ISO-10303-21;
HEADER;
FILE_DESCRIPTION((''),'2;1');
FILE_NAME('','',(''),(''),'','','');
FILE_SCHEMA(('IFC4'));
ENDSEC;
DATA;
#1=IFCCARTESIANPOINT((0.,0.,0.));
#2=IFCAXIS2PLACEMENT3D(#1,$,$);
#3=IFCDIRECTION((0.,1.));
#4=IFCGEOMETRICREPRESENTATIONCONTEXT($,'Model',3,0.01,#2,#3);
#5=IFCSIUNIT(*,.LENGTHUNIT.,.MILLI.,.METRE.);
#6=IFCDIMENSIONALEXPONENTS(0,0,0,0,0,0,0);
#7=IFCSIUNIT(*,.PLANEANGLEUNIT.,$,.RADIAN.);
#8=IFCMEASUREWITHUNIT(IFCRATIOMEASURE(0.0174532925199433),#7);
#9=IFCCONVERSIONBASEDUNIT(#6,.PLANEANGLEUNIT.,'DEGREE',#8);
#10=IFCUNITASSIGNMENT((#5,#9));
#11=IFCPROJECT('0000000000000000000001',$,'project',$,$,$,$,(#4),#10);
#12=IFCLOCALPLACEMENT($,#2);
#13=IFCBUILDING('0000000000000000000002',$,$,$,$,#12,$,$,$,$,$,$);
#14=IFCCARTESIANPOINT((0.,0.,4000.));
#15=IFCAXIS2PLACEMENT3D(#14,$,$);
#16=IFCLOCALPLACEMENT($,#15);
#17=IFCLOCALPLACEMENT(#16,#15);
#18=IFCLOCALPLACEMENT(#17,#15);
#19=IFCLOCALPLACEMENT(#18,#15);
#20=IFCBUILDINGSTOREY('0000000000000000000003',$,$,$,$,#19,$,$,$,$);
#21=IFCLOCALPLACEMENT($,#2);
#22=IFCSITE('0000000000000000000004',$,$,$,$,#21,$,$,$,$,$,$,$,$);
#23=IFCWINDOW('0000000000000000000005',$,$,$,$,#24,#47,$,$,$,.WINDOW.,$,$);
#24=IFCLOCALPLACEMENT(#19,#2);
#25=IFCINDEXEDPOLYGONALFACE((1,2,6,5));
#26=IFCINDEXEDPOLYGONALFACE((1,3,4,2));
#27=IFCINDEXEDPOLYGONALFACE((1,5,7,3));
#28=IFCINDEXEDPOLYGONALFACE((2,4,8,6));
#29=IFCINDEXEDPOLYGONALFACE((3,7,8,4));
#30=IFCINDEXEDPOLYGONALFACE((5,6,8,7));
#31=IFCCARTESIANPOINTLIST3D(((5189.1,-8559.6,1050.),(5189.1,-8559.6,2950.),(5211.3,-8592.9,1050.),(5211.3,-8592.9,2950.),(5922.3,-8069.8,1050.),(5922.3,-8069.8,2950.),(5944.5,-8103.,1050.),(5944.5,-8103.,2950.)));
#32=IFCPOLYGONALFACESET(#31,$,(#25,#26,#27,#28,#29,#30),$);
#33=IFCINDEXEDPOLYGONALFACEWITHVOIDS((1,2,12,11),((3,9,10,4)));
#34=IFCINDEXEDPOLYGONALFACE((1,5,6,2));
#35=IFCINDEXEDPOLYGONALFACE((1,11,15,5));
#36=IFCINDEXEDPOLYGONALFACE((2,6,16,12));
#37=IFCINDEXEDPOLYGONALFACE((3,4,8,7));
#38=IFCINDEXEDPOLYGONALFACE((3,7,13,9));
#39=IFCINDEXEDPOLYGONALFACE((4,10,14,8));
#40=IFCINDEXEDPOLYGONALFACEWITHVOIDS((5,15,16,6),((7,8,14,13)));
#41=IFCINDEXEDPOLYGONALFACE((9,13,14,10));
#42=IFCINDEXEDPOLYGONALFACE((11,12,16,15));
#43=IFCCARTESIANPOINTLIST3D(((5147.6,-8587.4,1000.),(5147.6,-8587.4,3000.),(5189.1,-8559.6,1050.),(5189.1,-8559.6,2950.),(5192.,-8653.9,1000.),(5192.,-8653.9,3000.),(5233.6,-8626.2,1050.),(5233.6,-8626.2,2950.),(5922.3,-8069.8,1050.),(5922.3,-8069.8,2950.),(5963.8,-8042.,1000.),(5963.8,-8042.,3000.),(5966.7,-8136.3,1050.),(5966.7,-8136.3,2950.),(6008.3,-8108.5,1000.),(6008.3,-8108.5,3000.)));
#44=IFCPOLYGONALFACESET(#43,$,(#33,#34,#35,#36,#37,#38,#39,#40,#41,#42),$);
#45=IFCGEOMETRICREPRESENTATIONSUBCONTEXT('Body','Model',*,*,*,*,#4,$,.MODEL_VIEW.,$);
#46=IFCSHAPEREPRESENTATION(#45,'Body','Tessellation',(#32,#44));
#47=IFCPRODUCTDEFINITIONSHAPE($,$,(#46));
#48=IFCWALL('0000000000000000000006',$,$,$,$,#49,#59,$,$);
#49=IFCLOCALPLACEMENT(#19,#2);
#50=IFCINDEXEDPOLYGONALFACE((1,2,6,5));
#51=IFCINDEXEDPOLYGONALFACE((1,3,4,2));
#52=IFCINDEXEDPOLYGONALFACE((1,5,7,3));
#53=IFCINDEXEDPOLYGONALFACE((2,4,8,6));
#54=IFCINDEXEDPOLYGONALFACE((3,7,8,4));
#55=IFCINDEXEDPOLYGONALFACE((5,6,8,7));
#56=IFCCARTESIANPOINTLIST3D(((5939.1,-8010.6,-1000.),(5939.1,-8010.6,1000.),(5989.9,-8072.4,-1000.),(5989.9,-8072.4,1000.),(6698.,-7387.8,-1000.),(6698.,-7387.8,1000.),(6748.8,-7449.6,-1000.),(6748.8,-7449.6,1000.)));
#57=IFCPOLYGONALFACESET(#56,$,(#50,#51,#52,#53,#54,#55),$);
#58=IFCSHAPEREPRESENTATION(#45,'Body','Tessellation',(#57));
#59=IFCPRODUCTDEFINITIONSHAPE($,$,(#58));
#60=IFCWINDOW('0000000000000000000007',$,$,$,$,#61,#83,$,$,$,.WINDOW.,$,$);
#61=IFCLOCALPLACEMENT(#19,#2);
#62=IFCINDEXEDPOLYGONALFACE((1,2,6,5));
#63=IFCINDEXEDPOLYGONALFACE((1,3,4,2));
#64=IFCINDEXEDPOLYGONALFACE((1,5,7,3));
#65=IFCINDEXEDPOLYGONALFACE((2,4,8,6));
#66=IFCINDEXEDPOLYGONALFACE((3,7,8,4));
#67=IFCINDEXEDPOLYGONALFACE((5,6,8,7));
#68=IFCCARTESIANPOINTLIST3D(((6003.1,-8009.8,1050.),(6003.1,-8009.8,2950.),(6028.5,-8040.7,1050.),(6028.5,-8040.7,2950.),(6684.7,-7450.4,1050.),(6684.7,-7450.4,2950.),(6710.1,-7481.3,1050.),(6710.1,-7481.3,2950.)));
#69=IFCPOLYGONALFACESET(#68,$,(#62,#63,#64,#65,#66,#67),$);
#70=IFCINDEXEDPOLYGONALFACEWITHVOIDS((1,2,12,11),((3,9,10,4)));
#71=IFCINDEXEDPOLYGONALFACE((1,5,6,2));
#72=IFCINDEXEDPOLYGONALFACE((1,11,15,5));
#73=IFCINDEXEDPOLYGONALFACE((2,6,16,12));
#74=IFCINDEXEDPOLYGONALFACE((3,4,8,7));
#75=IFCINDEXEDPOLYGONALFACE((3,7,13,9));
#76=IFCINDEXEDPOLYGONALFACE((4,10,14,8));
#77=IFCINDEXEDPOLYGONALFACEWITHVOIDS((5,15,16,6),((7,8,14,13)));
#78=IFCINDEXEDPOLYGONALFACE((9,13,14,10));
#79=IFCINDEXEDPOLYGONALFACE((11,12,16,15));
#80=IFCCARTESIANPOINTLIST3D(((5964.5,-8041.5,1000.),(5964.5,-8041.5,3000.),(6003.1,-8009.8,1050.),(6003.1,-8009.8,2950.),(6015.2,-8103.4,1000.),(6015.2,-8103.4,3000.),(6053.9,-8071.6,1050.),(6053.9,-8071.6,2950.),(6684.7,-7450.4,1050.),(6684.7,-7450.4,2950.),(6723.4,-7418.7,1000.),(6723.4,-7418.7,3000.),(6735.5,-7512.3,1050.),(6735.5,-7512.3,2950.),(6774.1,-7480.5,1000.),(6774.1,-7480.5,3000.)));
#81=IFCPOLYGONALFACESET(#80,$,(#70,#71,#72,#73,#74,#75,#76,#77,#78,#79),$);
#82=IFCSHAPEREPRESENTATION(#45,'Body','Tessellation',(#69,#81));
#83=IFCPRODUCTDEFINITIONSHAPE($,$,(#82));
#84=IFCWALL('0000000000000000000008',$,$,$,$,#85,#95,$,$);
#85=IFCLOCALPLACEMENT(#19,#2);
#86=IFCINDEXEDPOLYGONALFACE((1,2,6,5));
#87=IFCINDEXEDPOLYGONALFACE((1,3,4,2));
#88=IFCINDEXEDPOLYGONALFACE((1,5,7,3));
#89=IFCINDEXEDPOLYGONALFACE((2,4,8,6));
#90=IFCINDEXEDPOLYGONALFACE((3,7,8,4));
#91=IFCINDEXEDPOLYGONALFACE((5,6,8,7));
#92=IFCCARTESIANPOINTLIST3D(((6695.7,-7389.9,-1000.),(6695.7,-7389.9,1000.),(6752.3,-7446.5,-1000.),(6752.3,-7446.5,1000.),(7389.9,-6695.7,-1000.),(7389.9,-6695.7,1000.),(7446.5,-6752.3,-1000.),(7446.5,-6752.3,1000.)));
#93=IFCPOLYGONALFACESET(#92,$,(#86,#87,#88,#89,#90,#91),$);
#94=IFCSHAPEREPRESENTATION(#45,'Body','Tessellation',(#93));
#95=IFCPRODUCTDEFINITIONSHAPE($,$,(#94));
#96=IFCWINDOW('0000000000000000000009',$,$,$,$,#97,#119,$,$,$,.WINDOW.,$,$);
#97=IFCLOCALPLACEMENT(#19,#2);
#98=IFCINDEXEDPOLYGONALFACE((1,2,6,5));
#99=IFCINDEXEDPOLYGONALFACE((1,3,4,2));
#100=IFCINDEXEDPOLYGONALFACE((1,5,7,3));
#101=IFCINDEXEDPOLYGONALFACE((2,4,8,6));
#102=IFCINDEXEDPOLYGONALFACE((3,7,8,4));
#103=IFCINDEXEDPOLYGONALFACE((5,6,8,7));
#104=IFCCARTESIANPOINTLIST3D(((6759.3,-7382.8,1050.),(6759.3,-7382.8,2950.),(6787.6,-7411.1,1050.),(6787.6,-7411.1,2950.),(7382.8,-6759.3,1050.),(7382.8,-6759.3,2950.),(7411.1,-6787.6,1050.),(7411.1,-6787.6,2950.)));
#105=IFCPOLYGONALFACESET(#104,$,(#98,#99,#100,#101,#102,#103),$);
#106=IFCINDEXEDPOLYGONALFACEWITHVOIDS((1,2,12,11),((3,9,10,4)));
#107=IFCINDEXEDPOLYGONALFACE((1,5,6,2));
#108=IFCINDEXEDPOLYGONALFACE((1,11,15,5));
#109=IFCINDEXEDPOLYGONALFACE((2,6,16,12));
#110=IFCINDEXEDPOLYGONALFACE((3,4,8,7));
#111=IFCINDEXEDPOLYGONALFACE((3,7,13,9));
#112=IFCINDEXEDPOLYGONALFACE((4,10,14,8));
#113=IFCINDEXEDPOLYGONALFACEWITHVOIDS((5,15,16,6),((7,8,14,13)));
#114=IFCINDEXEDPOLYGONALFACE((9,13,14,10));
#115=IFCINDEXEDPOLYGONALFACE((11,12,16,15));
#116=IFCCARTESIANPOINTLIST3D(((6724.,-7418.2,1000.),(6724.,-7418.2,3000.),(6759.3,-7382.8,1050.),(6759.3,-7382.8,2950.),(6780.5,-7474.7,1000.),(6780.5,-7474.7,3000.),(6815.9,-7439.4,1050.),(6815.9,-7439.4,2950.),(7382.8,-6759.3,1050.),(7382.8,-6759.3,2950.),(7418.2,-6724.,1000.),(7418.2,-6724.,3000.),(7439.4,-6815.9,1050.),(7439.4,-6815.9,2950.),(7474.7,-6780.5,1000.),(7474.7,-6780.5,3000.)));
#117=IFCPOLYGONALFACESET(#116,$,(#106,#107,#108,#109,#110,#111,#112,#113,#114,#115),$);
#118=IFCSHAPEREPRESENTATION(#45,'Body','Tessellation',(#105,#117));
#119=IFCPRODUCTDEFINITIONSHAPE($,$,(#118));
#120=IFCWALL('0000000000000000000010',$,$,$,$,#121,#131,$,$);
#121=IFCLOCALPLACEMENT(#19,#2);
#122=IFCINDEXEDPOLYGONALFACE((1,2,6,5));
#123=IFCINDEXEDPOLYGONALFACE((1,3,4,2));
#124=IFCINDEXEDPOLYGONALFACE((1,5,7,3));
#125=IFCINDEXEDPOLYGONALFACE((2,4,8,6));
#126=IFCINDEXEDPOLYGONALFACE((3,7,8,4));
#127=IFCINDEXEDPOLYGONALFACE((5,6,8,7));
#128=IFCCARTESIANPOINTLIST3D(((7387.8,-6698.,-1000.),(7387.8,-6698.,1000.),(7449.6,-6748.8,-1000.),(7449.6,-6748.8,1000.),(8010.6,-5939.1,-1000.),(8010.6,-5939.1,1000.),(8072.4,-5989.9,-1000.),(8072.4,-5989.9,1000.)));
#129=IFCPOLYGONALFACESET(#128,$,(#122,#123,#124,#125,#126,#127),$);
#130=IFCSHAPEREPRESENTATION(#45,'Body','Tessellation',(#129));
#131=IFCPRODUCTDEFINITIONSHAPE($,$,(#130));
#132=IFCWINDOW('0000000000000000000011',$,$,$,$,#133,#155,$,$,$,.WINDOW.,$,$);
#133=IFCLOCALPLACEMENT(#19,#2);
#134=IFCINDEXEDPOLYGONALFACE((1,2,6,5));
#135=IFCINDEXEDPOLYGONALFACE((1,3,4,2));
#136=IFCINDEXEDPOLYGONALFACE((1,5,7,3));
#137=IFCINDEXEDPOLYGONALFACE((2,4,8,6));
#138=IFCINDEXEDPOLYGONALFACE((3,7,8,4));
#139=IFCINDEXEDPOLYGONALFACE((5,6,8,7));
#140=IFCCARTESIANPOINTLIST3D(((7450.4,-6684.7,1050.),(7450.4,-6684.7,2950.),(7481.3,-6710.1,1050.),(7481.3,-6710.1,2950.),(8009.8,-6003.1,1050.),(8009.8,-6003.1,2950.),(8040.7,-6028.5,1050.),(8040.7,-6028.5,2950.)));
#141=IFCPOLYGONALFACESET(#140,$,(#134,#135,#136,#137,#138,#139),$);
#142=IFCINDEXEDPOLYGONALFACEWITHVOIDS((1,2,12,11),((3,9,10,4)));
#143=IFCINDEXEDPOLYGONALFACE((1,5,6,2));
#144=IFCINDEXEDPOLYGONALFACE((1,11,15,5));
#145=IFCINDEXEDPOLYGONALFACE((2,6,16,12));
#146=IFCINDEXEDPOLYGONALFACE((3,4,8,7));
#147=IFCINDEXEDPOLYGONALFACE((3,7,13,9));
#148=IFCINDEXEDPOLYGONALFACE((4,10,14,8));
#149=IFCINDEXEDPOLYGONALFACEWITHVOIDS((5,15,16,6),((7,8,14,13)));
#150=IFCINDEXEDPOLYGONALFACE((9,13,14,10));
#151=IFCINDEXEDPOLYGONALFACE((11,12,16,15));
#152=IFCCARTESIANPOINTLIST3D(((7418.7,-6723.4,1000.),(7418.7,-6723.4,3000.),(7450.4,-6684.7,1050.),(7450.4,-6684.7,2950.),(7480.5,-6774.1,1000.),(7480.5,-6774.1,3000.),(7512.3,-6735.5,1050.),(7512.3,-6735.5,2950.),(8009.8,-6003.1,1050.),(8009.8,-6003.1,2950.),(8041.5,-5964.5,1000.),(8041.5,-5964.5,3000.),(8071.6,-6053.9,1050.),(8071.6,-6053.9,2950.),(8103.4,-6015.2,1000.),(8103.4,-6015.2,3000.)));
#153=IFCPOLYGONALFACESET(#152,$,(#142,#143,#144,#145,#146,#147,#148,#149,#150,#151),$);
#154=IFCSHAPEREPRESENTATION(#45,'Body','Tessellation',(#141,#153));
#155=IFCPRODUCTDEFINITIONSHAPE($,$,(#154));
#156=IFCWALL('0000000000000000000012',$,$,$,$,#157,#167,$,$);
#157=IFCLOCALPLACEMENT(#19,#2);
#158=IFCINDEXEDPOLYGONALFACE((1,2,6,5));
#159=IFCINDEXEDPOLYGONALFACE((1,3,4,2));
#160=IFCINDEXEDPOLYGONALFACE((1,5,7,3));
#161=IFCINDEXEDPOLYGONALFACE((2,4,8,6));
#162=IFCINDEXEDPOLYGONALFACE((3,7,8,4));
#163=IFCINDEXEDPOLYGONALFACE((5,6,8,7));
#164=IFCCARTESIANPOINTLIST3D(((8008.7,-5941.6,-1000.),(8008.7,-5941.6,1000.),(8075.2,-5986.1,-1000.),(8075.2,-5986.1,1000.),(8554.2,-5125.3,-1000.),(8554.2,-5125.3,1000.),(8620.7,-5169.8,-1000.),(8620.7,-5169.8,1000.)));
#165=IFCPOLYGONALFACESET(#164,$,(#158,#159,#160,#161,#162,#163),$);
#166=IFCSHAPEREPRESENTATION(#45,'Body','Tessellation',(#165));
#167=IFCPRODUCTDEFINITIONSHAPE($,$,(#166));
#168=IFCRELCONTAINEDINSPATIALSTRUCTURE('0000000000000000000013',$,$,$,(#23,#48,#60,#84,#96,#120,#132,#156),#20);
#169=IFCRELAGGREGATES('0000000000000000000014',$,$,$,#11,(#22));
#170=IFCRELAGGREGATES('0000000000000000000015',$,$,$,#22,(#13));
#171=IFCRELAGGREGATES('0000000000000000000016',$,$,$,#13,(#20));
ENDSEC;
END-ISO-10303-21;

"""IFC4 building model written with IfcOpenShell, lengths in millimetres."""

from ifc_helpers import new_model, entity, si_unit, converted_unit, direction, frame, origin, origin_2d, place, context, subcontext, project, spatial, rectangle, extrude, element, save


model = new_model("IFC4")

# Units and contexts
model_context = context("Model", 3, precision=0.01, world=origin(), true_north=direction((0.0, 1.0)))
body_context = subcontext(model_context, "Body", "Model", "MODEL_VIEW")
ifc_project = project(units=[si_unit("LENGTHUNIT", "METRE", prefix="MILLI"), converted_unit("PLANEANGLEUNIT", "DEGREE", entity("IfcRatioMeasure", 0.0174532925199433), si_unit("PLANEANGLEUNIT", "RADIAN"), dimensions=[0, 0, 0, 0, 0, 0, 0])], contexts=[model_context])

# Site, building, storey
site_placement = place(None, origin())
site = spatial("IfcSite", under=ifc_project, at=site_placement)
building_placement = place(None, origin())
building = spatial("IfcBuilding", under=site, at=building_placement)
placement_1 = place(None, frame((0.0, 0.0, 4000.0)))
placement_2 = place(placement_1, frame((0.0, 0.0, 4000.0)))
placement_3 = place(placement_2, frame((0.0, 0.0, 4000.0)))
storey_placement = place(placement_3, frame((0.0, 0.0, 4000.0)))
storey = spatial("IfcBuildingStorey", under=building, at=storey_placement)

# Shared definitions
cartesian_point_1 = entity("IfcCartesianPoint", [-440.9, -950.0])
shared_polyline = entity("IfcPolyline", [cartesian_point_1, entity("IfcCartesianPoint", [-440.9, 950.0]), entity("IfcCartesianPoint", [-440.9, 950.0]), entity("IfcCartesianPoint", [440.9, 950.0]), entity("IfcCartesianPoint", [440.9, 950.0]), entity("IfcCartesianPoint", [440.9, -950.0]), entity("IfcCartesianPoint", [440.9, -950.0]), entity("IfcCartesianPoint", [-440.9, -950.0]), cartesian_point_1])

# Window
window_1_placement = place(storey_placement, frame((5555.7, -8314.7, 2000.0), z_axis=(0.0, 0.0, 1.0), x_axis=(8314.697373, 5555.700459, 0.0)))
cartesian_point_2 = entity("IfcCartesianPoint", [-490.9, -1000.0])
element("IfcWindow", 1, at=window_1_placement, inside=storey, PredefinedType="WINDOW", context=body_context, shape_type="SweptSolid", body=[
    entity("IfcExtrudedAreaSolid", entity("IfcArbitraryClosedProfileDef", "AREA", None, shared_polyline), entity("IfcAxis2Placement3D", entity("IfcCartesianPoint", [0.0, 0.0, 0.0]), entity("IfcDirection", [0.0, -1.0, 0.0]), entity("IfcDirection", [1.0, 0.0, 0.0])), entity("IfcDirection", [0.0, 0.0, 1.0]), 40.0),
    entity("IfcExtrudedAreaSolid", entity("IfcArbitraryProfileDefWithVoids", "AREA", None, entity("IfcPolyline", [cartesian_point_2, entity("IfcCartesianPoint", [-490.9, 1000.0]), entity("IfcCartesianPoint", [-490.9, 1000.0]), entity("IfcCartesianPoint", [490.9, 1000.0]), entity("IfcCartesianPoint", [490.9, 1000.0]), entity("IfcCartesianPoint", [490.9, -1000.0]), entity("IfcCartesianPoint", [490.9, -1000.0]), entity("IfcCartesianPoint", [-490.9, -1000.0]), cartesian_point_2]), [shared_polyline]), entity("IfcAxis2Placement3D", entity("IfcCartesianPoint", [0.0, 0.0, 0.0]), entity("IfcDirection", [0.0, -1.0, 0.0]), entity("IfcDirection", [1.0, 0.0, 0.0])), entity("IfcDirection", [0.0, 0.0, 1.0]), 80.0),
])

# Wall
wall_1_placement = place(storey_placement, frame((6343.9, -7730.1, -1000.0), z_axis=(0.0, 0.0, 1.0), x_axis=(7730.104195, 6343.933254, 0.0)))
element("IfcWall", 2, at=wall_1_placement, inside=storey, context=body_context, shape_type="SweptSolid", body=[
    extrude(rectangle(XDim=981.7, YDim=80.0, at=origin_2d()), origin(), (0.0, 0.0, 1.0), 2000.0),
])

# Window
window_2_placement = place(storey_placement, frame((6343.9, -7730.1, 2000.0), z_axis=(0.0, 0.0, 1.0), x_axis=(7730.104195, 6343.933254, 0.0)))
cartesian_point_3 = entity("IfcCartesianPoint", [-490.9, -1000.0])
element("IfcWindow", 3, at=window_2_placement, inside=storey, PredefinedType="WINDOW", context=body_context, shape_type="SweptSolid", body=[
    entity("IfcExtrudedAreaSolid", entity("IfcArbitraryClosedProfileDef", "AREA", None, shared_polyline), entity("IfcAxis2Placement3D", entity("IfcCartesianPoint", [0.0, 0.0, 0.0]), entity("IfcDirection", [0.0, -1.0, 0.0]), entity("IfcDirection", [1.0, 0.0, 0.0])), entity("IfcDirection", [0.0, 0.0, 1.0]), 40.0),
    entity("IfcExtrudedAreaSolid", entity("IfcArbitraryProfileDefWithVoids", "AREA", None, entity("IfcPolyline", [cartesian_point_3, entity("IfcCartesianPoint", [-490.9, 1000.0]), entity("IfcCartesianPoint", [-490.9, 1000.0]), entity("IfcCartesianPoint", [490.9, 1000.0]), entity("IfcCartesianPoint", [490.9, 1000.0]), entity("IfcCartesianPoint", [490.9, -1000.0]), entity("IfcCartesianPoint", [490.9, -1000.0]), entity("IfcCartesianPoint", [-490.9, -1000.0]), cartesian_point_3]), [shared_polyline]), entity("IfcAxis2Placement3D", entity("IfcCartesianPoint", [0.0, 0.0, 0.0]), entity("IfcDirection", [0.0, -1.0, 0.0]), entity("IfcDirection", [1.0, 0.0, 0.0])), entity("IfcDirection", [0.0, 0.0, 1.0]), 80.0),
])

# Wall
wall_2_placement = place(storey_placement, frame((7071.1, -7071.1, -1000.0), z_axis=(0.0, 0.0, 1.0), x_axis=(7071.068837, 7071.066786, 0.0)))
element("IfcWall", 4, at=wall_2_placement, inside=storey, context=body_context, shape_type="SweptSolid", body=[
    extrude(rectangle(XDim=981.7, YDim=80.0, at=origin_2d()), origin(), (0.0, 0.0, 1.0), 2000.0),
])

# Window
window_3_placement = place(storey_placement, frame((7071.1, -7071.1, 2000.0), z_axis=(0.0, 0.0, 1.0), x_axis=(7071.068837, 7071.066786, 0.0)))
cartesian_point_4 = entity("IfcCartesianPoint", [-490.9, -1000.0])
element("IfcWindow", 5, at=window_3_placement, inside=storey, PredefinedType="WINDOW", context=body_context, shape_type="SweptSolid", body=[
    entity("IfcExtrudedAreaSolid", entity("IfcArbitraryClosedProfileDef", "AREA", None, shared_polyline), entity("IfcAxis2Placement3D", entity("IfcCartesianPoint", [0.0, 0.0, 0.0]), entity("IfcDirection", [0.0, -1.0, 0.0]), entity("IfcDirection", [1.0, 0.0, 0.0])), entity("IfcDirection", [0.0, 0.0, 1.0]), 40.0),
    entity("IfcExtrudedAreaSolid", entity("IfcArbitraryProfileDefWithVoids", "AREA", None, entity("IfcPolyline", [cartesian_point_4, entity("IfcCartesianPoint", [-490.9, 1000.0]), entity("IfcCartesianPoint", [-490.9, 1000.0]), entity("IfcCartesianPoint", [490.9, 1000.0]), entity("IfcCartesianPoint", [490.9, 1000.0]), entity("IfcCartesianPoint", [490.9, -1000.0]), entity("IfcCartesianPoint", [490.9, -1000.0]), entity("IfcCartesianPoint", [-490.9, -1000.0]), cartesian_point_4]), [shared_polyline]), entity("IfcAxis2Placement3D", entity("IfcCartesianPoint", [0.0, 0.0, 0.0]), entity("IfcDirection", [0.0, -1.0, 0.0]), entity("IfcDirection", [1.0, 0.0, 0.0])), entity("IfcDirection", [0.0, 0.0, 1.0]), 80.0),
])

# Wall
wall_3_placement = place(storey_placement, frame((7730.1, -6343.9, -1000.0), z_axis=(0.0, 0.0, 1.0), x_axis=(6343.931811, 7730.10538, 0.0)))
element("IfcWall", 6, at=wall_3_placement, inside=storey, context=body_context, shape_type="SweptSolid", body=[
    extrude(rectangle(XDim=981.7, YDim=80.0, at=origin_2d()), origin(), (0.0, 0.0, 1.0), 2000.0),
])

# Window
window_4_placement = place(storey_placement, frame((7730.1, -6343.9, 2000.0), z_axis=(0.0, 0.0, 1.0), x_axis=(6343.931811, 7730.10538, 0.0)))
cartesian_point_5 = entity("IfcCartesianPoint", [-490.9, -1000.0])
element("IfcWindow", 7, at=window_4_placement, inside=storey, PredefinedType="WINDOW", context=body_context, shape_type="SweptSolid", body=[
    entity("IfcExtrudedAreaSolid", entity("IfcArbitraryClosedProfileDef", "AREA", None, shared_polyline), entity("IfcAxis2Placement3D", entity("IfcCartesianPoint", [0.0, 0.0, 0.0]), entity("IfcDirection", [0.0, -1.0, 0.0]), entity("IfcDirection", [1.0, 0.0, 0.0])), entity("IfcDirection", [0.0, 0.0, 1.0]), 40.0),
    entity("IfcExtrudedAreaSolid", entity("IfcArbitraryProfileDefWithVoids", "AREA", None, entity("IfcPolyline", [cartesian_point_5, entity("IfcCartesianPoint", [-490.9, 1000.0]), entity("IfcCartesianPoint", [-490.9, 1000.0]), entity("IfcCartesianPoint", [490.9, 1000.0]), entity("IfcCartesianPoint", [490.9, 1000.0]), entity("IfcCartesianPoint", [490.9, -1000.0]), entity("IfcCartesianPoint", [490.9, -1000.0]), entity("IfcCartesianPoint", [-490.9, -1000.0]), cartesian_point_5]), [shared_polyline]), entity("IfcAxis2Placement3D", entity("IfcCartesianPoint", [0.0, 0.0, 0.0]), entity("IfcDirection", [0.0, -1.0, 0.0]), entity("IfcDirection", [1.0, 0.0, 0.0])), entity("IfcDirection", [0.0, 0.0, 1.0]), 80.0),
])

# Wall
wall_4_placement = place(storey_placement, frame((8314.7, -5555.7, -1000.0), z_axis=(0.0, 0.0, 1.0), x_axis=(5555.702871, 8314.695762, 0.0)))
element("IfcWall", 8, at=wall_4_placement, inside=storey, context=body_context, shape_type="SweptSolid", body=[
    extrude(rectangle(XDim=981.7, YDim=80.0, at=origin_2d()), origin(), (0.0, 0.0, 1.0), 2000.0),
])

save(model, "model.ifc")
